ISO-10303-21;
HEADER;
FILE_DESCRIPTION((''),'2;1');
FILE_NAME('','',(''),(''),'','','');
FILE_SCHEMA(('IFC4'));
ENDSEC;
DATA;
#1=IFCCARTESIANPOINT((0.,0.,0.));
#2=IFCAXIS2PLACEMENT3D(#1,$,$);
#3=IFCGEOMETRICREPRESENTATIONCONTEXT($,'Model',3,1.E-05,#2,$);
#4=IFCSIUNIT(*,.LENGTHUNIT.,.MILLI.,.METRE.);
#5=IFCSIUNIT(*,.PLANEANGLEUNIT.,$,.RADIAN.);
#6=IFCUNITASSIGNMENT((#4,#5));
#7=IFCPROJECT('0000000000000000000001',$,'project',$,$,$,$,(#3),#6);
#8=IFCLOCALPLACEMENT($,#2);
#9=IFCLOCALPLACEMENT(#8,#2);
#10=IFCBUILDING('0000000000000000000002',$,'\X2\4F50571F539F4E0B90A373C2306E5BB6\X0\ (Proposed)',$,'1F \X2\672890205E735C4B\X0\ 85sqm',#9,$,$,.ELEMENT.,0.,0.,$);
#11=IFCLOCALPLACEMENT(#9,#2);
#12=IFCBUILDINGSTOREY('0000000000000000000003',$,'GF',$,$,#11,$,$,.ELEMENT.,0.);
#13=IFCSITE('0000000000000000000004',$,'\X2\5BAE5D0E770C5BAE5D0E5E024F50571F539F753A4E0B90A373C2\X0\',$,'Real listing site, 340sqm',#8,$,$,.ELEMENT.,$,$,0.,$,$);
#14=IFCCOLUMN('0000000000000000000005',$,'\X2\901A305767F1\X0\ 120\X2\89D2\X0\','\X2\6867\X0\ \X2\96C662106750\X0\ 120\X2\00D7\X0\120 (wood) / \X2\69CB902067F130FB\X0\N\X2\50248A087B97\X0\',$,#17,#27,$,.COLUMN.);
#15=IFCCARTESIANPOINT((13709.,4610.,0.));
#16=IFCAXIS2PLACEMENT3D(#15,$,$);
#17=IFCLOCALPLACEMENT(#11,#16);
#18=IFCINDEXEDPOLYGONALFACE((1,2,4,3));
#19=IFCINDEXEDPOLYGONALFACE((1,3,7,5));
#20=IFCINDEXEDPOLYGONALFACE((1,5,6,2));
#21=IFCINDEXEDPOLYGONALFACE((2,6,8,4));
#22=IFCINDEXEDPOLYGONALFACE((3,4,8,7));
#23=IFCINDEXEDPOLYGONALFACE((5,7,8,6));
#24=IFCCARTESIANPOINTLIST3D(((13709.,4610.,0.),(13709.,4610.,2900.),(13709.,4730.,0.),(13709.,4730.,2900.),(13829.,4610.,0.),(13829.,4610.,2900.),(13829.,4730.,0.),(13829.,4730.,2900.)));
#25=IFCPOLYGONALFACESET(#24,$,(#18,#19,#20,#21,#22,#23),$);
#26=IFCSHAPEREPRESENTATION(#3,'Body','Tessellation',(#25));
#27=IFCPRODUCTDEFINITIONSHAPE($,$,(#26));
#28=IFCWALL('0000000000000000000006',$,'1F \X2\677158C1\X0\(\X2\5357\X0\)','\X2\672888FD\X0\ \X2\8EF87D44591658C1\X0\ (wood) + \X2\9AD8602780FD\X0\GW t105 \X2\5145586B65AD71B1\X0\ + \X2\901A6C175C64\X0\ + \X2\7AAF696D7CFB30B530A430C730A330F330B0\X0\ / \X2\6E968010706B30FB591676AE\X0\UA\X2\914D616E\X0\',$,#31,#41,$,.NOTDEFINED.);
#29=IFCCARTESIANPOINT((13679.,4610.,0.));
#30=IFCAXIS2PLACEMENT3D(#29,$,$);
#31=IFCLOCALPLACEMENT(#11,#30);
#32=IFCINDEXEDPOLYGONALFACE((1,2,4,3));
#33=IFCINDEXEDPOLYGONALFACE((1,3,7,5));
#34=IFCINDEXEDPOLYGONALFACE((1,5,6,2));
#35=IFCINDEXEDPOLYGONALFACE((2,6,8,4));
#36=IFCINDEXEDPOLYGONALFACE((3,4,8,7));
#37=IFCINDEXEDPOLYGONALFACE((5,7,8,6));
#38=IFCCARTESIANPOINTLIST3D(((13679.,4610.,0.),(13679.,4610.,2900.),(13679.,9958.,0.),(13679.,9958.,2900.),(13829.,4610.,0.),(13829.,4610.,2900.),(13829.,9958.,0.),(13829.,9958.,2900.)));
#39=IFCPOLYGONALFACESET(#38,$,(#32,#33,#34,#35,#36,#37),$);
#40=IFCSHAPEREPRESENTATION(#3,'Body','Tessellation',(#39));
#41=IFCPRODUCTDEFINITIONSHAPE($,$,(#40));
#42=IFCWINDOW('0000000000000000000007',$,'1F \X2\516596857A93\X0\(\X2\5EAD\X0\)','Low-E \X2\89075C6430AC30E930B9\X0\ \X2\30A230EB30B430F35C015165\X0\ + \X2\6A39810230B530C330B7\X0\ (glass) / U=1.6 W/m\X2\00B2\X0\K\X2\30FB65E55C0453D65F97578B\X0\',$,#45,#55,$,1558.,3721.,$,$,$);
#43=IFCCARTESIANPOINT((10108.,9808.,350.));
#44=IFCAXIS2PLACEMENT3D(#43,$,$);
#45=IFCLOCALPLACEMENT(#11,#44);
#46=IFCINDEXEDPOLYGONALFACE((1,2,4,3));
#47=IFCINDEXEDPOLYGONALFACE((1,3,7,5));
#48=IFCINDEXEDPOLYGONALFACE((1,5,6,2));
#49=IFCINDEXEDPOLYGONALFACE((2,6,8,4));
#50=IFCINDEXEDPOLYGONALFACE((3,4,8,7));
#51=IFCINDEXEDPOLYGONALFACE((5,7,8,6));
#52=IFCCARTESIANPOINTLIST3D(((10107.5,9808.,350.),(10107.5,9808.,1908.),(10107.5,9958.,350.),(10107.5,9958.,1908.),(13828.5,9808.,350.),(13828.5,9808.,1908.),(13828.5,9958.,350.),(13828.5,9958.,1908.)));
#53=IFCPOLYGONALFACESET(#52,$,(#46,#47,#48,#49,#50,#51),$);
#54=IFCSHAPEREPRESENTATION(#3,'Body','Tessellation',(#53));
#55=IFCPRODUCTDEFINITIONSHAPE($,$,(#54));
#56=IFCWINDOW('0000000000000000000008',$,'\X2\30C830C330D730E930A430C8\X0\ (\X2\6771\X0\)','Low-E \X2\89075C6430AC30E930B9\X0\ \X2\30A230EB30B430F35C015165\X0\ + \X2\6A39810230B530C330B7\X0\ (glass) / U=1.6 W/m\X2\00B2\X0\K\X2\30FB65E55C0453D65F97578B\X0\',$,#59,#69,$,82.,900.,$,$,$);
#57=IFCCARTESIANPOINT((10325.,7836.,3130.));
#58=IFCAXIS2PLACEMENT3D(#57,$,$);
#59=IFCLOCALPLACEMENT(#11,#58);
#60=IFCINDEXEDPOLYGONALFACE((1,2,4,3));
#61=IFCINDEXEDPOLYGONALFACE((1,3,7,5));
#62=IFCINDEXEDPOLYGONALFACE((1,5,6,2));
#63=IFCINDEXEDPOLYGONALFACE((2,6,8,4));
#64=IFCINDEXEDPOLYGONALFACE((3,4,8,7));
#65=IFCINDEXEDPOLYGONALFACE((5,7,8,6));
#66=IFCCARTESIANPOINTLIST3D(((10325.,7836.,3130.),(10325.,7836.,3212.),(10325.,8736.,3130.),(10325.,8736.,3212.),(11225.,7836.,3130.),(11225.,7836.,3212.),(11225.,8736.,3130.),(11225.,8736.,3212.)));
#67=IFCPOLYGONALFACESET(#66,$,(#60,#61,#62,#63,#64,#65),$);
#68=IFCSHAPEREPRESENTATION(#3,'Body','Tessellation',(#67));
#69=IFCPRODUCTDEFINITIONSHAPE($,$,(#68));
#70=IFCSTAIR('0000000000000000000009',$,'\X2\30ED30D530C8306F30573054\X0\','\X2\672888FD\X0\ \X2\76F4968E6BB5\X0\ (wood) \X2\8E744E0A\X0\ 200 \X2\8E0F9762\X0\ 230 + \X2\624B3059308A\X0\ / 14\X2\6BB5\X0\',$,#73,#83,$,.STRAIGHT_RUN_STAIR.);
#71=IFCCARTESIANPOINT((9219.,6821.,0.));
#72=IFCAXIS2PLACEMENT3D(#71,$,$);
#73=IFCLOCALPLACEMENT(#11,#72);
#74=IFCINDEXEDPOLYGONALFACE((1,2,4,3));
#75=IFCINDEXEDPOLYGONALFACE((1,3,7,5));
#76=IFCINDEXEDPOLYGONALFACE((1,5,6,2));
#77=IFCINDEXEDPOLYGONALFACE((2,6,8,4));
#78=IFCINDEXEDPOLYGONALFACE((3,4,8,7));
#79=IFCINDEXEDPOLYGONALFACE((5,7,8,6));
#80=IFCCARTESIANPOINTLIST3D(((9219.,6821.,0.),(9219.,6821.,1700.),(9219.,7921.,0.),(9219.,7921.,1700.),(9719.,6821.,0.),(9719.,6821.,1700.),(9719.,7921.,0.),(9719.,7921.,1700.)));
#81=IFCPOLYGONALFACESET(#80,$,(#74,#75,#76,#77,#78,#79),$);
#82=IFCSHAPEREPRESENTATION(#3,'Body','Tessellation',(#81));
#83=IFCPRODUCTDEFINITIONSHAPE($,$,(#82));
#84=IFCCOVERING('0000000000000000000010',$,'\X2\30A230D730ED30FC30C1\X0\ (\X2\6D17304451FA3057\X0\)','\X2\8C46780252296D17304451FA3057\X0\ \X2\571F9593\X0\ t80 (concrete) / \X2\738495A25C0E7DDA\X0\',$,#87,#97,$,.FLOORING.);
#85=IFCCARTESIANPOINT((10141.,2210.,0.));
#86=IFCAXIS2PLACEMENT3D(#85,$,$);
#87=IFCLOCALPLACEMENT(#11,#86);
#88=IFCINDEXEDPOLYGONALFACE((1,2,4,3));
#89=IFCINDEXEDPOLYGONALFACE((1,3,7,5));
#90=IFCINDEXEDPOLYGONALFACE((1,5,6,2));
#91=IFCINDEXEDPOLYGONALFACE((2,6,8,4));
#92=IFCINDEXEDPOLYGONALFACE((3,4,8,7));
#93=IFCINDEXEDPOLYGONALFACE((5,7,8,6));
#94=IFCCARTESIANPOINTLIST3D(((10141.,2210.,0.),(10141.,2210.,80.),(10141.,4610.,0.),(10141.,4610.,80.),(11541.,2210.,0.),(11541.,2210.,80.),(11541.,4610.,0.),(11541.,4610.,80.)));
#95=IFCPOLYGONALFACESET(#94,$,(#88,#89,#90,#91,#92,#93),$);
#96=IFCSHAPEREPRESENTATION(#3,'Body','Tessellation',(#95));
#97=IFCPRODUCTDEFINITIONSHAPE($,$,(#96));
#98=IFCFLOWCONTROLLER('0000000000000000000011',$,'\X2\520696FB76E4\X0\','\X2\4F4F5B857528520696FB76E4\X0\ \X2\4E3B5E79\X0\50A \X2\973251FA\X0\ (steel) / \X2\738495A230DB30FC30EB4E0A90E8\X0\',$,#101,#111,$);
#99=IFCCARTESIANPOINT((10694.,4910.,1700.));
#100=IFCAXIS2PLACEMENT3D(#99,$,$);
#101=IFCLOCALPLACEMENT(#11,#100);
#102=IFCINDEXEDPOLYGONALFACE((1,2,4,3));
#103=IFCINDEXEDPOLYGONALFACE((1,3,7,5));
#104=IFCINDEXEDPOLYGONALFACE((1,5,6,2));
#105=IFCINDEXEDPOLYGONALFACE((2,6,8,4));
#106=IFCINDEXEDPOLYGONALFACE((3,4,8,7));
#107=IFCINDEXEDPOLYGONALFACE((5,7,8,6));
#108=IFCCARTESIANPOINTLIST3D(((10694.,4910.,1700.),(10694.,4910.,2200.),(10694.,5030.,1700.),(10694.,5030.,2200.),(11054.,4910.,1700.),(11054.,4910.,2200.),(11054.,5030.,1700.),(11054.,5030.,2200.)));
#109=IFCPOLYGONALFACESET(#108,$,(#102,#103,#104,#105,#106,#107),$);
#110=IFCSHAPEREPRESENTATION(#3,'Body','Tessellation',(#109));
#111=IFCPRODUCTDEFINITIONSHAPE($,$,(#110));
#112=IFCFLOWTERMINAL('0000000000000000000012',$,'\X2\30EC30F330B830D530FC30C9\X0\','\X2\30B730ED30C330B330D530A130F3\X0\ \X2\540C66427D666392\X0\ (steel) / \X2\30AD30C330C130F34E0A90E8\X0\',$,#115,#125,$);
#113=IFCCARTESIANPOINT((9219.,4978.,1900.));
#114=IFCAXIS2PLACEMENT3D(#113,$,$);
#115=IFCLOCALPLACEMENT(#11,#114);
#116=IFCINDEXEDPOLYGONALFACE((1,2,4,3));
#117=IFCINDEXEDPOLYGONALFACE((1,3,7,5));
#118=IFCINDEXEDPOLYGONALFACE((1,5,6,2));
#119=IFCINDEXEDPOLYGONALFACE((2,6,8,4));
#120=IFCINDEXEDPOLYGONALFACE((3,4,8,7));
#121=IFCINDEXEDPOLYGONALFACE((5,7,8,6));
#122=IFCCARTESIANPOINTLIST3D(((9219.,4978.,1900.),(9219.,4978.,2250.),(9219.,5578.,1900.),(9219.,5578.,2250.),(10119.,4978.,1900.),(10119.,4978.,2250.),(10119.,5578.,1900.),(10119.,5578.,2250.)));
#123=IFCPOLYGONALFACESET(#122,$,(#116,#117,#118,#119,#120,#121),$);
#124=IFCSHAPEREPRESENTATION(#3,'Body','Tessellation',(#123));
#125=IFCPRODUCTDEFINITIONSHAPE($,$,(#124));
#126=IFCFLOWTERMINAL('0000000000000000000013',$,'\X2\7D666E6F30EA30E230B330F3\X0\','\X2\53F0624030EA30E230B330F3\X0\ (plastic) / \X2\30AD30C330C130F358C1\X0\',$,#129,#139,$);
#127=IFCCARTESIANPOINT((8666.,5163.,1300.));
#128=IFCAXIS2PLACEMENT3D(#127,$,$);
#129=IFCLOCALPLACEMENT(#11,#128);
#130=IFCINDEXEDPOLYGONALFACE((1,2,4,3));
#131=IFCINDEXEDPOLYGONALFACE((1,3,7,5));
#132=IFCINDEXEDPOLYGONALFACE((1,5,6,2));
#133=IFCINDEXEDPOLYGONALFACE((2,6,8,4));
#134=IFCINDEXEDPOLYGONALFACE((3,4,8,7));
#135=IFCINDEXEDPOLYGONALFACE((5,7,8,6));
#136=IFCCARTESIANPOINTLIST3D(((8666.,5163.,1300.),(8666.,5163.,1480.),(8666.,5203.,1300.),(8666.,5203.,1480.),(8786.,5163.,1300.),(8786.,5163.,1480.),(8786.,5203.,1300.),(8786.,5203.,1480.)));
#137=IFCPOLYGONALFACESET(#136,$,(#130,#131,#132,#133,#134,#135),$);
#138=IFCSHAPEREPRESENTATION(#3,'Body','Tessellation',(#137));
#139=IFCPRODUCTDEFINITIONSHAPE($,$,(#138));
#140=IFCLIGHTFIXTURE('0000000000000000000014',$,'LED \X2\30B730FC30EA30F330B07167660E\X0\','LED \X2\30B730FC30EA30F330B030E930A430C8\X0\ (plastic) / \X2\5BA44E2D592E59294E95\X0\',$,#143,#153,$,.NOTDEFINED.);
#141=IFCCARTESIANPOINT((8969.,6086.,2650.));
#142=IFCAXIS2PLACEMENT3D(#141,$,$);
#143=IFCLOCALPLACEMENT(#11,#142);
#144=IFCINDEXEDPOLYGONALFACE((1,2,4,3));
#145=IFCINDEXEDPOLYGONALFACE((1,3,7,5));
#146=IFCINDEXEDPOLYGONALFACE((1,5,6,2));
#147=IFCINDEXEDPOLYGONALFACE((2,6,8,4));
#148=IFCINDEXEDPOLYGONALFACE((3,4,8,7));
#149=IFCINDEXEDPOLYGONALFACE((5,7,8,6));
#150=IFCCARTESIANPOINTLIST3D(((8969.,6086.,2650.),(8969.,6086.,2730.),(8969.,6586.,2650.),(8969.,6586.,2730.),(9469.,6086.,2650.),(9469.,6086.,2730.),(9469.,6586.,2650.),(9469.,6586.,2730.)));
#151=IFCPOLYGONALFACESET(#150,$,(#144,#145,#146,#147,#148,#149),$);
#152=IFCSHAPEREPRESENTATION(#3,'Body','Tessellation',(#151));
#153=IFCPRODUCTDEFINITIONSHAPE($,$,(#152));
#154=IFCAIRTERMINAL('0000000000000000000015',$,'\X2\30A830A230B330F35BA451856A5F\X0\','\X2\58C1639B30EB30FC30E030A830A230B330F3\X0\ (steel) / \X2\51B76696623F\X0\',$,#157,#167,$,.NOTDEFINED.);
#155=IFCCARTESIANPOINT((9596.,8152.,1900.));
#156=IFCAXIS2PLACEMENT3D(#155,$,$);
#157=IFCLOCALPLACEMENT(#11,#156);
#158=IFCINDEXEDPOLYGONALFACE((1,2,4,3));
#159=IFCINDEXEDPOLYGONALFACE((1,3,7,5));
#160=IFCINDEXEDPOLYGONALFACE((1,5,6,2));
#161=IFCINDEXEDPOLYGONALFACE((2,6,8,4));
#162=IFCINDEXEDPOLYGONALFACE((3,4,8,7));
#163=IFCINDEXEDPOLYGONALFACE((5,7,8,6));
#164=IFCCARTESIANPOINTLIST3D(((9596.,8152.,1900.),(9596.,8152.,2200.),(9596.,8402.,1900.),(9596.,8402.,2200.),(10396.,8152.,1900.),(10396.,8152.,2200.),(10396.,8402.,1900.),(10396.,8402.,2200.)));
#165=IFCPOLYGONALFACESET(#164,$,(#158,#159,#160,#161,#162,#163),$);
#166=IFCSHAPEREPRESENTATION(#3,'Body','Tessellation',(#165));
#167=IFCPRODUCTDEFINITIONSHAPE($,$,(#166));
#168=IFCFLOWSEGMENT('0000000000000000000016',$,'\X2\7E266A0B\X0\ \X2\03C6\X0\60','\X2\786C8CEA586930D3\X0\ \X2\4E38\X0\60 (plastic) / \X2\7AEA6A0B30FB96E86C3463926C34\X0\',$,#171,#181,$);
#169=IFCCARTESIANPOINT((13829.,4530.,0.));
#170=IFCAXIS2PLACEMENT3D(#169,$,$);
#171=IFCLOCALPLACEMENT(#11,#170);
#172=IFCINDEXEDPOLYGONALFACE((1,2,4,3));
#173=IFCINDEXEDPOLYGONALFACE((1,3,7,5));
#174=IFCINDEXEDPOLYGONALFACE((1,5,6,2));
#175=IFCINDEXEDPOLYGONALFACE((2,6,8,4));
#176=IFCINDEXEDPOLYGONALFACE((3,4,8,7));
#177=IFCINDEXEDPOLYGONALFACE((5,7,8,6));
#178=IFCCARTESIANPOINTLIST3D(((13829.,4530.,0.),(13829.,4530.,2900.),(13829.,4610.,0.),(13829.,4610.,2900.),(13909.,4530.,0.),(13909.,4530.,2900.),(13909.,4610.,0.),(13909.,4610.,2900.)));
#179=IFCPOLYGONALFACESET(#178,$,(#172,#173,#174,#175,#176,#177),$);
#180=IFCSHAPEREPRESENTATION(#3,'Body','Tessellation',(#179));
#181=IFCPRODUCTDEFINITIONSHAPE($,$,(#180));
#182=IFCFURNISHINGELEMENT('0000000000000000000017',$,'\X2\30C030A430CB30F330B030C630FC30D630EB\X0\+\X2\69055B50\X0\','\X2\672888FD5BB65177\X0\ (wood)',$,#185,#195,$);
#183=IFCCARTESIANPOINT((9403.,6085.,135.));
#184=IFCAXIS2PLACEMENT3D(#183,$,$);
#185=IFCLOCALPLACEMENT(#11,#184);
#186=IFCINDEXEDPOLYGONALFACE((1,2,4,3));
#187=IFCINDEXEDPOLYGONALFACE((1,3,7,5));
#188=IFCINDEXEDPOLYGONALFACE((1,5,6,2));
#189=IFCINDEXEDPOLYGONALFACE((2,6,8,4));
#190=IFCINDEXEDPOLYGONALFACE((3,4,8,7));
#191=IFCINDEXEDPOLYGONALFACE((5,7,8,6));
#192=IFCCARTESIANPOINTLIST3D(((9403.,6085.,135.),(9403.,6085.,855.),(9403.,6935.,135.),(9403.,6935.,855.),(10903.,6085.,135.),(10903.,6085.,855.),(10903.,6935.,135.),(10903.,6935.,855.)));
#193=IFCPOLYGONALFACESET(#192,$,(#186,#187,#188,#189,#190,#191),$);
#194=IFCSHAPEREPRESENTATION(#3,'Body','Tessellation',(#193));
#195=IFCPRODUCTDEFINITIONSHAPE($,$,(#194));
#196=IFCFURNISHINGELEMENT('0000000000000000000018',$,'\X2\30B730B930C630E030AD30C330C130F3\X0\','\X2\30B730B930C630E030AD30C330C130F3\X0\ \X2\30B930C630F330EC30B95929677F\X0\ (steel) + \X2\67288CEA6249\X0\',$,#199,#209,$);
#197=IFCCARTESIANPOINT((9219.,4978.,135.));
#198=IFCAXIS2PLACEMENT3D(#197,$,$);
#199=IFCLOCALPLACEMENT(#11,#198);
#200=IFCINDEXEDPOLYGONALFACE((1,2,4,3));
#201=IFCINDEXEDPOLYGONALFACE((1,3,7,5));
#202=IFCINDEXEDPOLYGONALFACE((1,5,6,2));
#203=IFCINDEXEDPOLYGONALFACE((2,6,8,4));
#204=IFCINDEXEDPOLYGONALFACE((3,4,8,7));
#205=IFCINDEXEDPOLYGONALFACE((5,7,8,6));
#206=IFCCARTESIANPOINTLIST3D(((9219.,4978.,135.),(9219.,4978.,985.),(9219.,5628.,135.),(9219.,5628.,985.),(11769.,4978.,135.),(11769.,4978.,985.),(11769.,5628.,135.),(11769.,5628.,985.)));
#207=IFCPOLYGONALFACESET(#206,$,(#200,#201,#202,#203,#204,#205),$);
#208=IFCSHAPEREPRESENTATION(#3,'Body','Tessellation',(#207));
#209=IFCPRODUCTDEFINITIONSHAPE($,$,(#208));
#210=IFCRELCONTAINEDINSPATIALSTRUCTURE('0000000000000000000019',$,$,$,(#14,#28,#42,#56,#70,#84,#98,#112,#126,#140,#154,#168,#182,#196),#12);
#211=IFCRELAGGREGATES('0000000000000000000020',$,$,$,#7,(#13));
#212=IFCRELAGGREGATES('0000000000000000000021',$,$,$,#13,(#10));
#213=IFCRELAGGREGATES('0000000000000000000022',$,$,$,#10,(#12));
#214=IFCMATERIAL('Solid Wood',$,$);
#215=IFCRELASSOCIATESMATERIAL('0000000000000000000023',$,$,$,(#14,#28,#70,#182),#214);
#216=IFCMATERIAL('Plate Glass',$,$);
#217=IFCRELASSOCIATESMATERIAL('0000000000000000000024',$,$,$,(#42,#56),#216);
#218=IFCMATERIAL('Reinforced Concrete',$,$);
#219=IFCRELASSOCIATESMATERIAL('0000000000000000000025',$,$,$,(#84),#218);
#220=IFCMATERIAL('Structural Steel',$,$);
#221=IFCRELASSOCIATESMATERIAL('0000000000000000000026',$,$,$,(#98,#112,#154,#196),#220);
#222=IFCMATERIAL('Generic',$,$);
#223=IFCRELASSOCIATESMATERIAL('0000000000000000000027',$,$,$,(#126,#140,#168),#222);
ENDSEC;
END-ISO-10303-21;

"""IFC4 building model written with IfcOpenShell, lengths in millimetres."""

from ifc_helpers import new_model, si_unit, frame, frame_2d, origin, place, context, project, spatial, rectangle, extrude, material, element, fill, save


model = new_model("IFC4")

# Units and contexts
model_context = context("Model", 3, precision=1e-05, world=origin())
ifc_project = project(units=[si_unit("LENGTHUNIT", "METRE", prefix="MILLI"), si_unit("PLANEANGLEUNIT", "RADIAN")], contexts=[model_context])

# Site, building, storey
site_placement = place(None, origin())
site = spatial("IfcSite", under=ifc_project, at=site_placement, Name="宮崎県宮崎市佐土原町下那珂", ObjectType="Real listing site, 340sqm", CompositionType="ELEMENT", RefElevation=0.0)
building_placement = place(site_placement, origin())
building = spatial("IfcBuilding", under=site, at=building_placement, Name="佐土原下那珂の家 (Proposed)", ObjectType="1F 木造平屋 85sqm", CompositionType="ELEMENT", ElevationOfRefHeight=0.0, ElevationOfTerrain=0.0)
storey_placement = place(building_placement, origin())
storey = spatial("IfcBuildingStorey", under=building, at=storey_placement, Name="GF", CompositionType="ELEMENT", Elevation=0.0)

# Column
ifc_material_1 = material(Name="Solid Wood")
column_1_placement = place(storey_placement, frame((13709.0, 4610.0, 0.0)))
element("IfcColumn", 1, at=column_1_placement, inside=storey, material=ifc_material_1, Name="通し柱 120角", Description="桧 集成材 120×120 (wood) / 構造柱・N値計算", PredefinedType="COLUMN", context=model_context, shape_type="SweptSolid", body=[
    extrude(rectangle(XDim=120.0, YDim=120.0, at=frame_2d((60.0, 60.0))), frame((13709.0, 4610.0, 0.0)), (0.0, 0.0, 1.0), 2900.0),
])

# Wall, opening, window
wall_1_placement = place(storey_placement, frame((13679.0, 4610.0, 0.0)))
wall_1 = element("IfcWall", 2, at=wall_1_placement, inside=storey, material=ifc_material_1, Name="1F 東壁(南)", Description="木製 軸組外壁 (wood) + 高性能GW t105 充填断熱 + 通気層 + 窯業系サイディング / 準耐火・外皮UA配慮", PredefinedType="NOTDEFINED", context=model_context, shape_type="SweptSolid", body=[
    extrude(rectangle(XDim=150.0, YDim=5348.0, at=frame_2d((75.0, 2674.0))), frame((13679.0, 4610.0, 0.0)), (0.0, 0.0, 1.0), 2900.0),
])
opening_placement = place(storey_placement, frame((10108.0, 9808.0, 350.0)))
opening = element("IfcOpeningElement", 3, at=opening_placement, cuts=wall_1, PredefinedType="NOTDEFINED", context=model_context, shape_type="SweptSolid", body=[
    extrude(rectangle(XDim=3721.0, YDim=150.0, at=frame_2d((1860.0, 75.0))), frame((10108.0, 9808.0, 350.0)), (0.0, 0.0, 1.0), 1558.0),
])
ifc_material_2 = material(Name="Plate Glass")
window_1_placement = place(storey_placement, frame((10108.0, 9808.0, 350.0)))
window_1 = element("IfcWindow", 4, at=window_1_placement, inside=storey, material=ifc_material_2, Name="1F 入隅窓(庭)", Description="Low-E 複層ガラス アルゴン封入 + 樹脂サッシ (glass) / U=1.6 W/m²K・日射取得型", OverallHeight=1558.0, OverallWidth=3721.0, context=model_context, shape_type="SweptSolid", body=[
    extrude(rectangle(XDim=3721.0, YDim=150.0, at=frame_2d((1860.0, 75.0))), frame((10108.0, 9808.0, 350.0)), (0.0, 0.0, 1.0), 1558.0),
])
fill(opening, window_1)

# Window
window_2_placement = place(storey_placement, frame((10325.0, 7836.0, 3130.0)))
element("IfcWindow", 5, at=window_2_placement, inside=storey, material=ifc_material_2, Name="トップライト (東)", Description="Low-E 複層ガラス アルゴン封入 + 樹脂サッシ (glass) / U=1.6 W/m²K・日射取得型", OverallHeight=82.0, OverallWidth=900.0, context=model_context, shape_type="SweptSolid", body=[
    extrude(rectangle(XDim=900.0, YDim=900.0, at=frame_2d((450.0, 450.0))), frame((10325.0, 7836.0, 3130.0)), (0.0, 0.0, 1.0), 82.0),
])

# Stair
stair_placement = place(storey_placement, frame((9219.0, 6821.0, 0.0)))
element("IfcStair", 6, at=stair_placement, inside=storey, material=ifc_material_1, Name="ロフトはしご", Description="木製 直階段 (wood) 蹴上 200 踏面 230 + 手すり / 14段", PredefinedType="STRAIGHT_RUN_STAIR", context=model_context, shape_type="SweptSolid", body=[
    extrude(rectangle(XDim=500.0, YDim=1100.0, at=frame_2d((250.0, 550.0))), frame((9219.0, 6821.0, 0.0)), (0.0, 0.0, 1.0), 1700.0),
])

# Covering
ifc_material_3 = material(Name="Reinforced Concrete")
covering_placement = place(storey_placement, frame((10141.0, 2210.0, 0.0)))
element("IfcCovering", 7, at=covering_placement, inside=storey, material=ifc_material_3, Name="アプローチ (洗い出し)", Description="豆砂利洗い出し 土間 t80 (concrete) / 玄関導線", PredefinedType="FLOORING", context=model_context, shape_type="SweptSolid", body=[
    extrude(rectangle(XDim=1400.0, YDim=2400.0, at=frame_2d((700.0, 1200.0))), frame((10141.0, 2210.0, 0.0)), (0.0, 0.0, 1.0), 80.0),
])

# Flow controller
ifc_material_4 = material(Name="Structural Steel")
flow_controller_placement = place(storey_placement, frame((10694.0, 4910.0, 1700.0)))
element("IfcFlowController", 8, at=flow_controller_placement, inside=storey, material=ifc_material_4, Name="分電盤", Description="住宅用分電盤 主幹50A 露出 (steel) / 玄関ホール上部", context=model_context, shape_type="SweptSolid", body=[
    extrude(rectangle(XDim=360.0, YDim=120.0, at=frame_2d((180.0, 60.0))), frame((10694.0, 4910.0, 1700.0)), (0.0, 0.0, 1.0), 500.0),
])

# Flow terminals
flow_terminal_1_placement = place(storey_placement, frame((9219.0, 4978.0, 1900.0)))
element("IfcFlowTerminal", 9, at=flow_terminal_1_placement, inside=storey, material=ifc_material_4, Name="レンジフード", Description="シロッコファン 同時給排 (steel) / キッチン上部", context=model_context, shape_type="SweptSolid", body=[
    extrude(rectangle(XDim=900.0, YDim=600.0, at=frame_2d((450.0, 300.0))), frame((9219.0, 4978.0, 1900.0)), (0.0, 0.0, 1.0), 350.0),
])
ifc_material_5 = material(Name="Generic")
flow_terminal_2_placement = place(storey_placement, frame((8666.0, 5163.0, 1300.0)))
element("IfcFlowTerminal", 10, at=flow_terminal_2_placement, inside=storey, material=ifc_material_5, Name="給湯リモコン", Description="台所リモコン (plastic) / キッチン壁", context=model_context, shape_type="SweptSolid", body=[
    extrude(rectangle(XDim=120.0, YDim=40.0, at=frame_2d((60.0, 20.0))), frame((8666.0, 5163.0, 1300.0)), (0.0, 0.0, 1.0), 180.0),
])

# Light fixture
light_fixture_placement = place(storey_placement, frame((8969.0, 6086.0, 2650.0)))
element("IfcLightFixture", 11, at=light_fixture_placement, inside=storey, material=ifc_material_5, Name="LED シーリング照明", Description="LED シーリングライト (plastic) / 室中央天井", PredefinedType="NOTDEFINED", context=model_context, shape_type="SweptSolid", body=[
    extrude(rectangle(XDim=500.0, YDim=500.0, at=frame_2d((250.0, 250.0))), frame((8969.0, 6086.0, 2650.0)), (0.0, 0.0, 1.0), 80.0),
])

# Air terminal
air_terminal_placement = place(storey_placement, frame((9596.0, 8152.0, 1900.0)))
element("IfcAirTerminal", 12, at=air_terminal_placement, inside=storey, material=ifc_material_4, Name="エアコン室内機", Description="壁掛ルームエアコン (steel) / 冷暖房", PredefinedType="NOTDEFINED", context=model_context, shape_type="SweptSolid", body=[
    extrude(rectangle(XDim=800.0, YDim=250.0, at=frame_2d((400.0, 125.0))), frame((9596.0, 8152.0, 1900.0)), (0.0, 0.0, 1.0), 300.0),
])

# Flow segment
flow_segment_placement = place(storey_placement, frame((13829.0, 4530.0, 0.0)))
element("IfcFlowSegment", 13, at=flow_segment_placement, inside=storey, material=ifc_material_5, Name="縦樋 φ60", Description="硬質塩ビ 丸60 (plastic) / 竪樋・雨水排水", context=model_context, shape_type="SweptSolid", body=[
    extrude(rectangle(XDim=80.0, YDim=80.0, at=frame_2d((40.0, 40.0))), frame((13829.0, 4530.0, 0.0)), (0.0, 0.0, 1.0), 2900.0),
])

# Furnishing elements
furnishing_1_placement = place(storey_placement, frame((9403.0, 6085.0, 135.0)))
element("IfcFurnishingElement", 14, at=furnishing_1_placement, inside=storey, material=ifc_material_1, Name="ダイニングテーブル+椅子", Description="木製家具 (wood)", context=model_context, shape_type="SweptSolid", body=[
    extrude(rectangle(XDim=1500.0, YDim=850.0, at=frame_2d((750.0, 425.0))), frame((9403.0, 6085.0, 135.0)), (0.0, 0.0, 1.0), 720.0),
])
furnishing_2_placement = place(storey_placement, frame((9219.0, 4978.0, 135.0)))
element("IfcFurnishingElement", 15, at=furnishing_2_placement, inside=storey, material=ifc_material_4, Name="システムキッチン", Description="システムキッチン ステンレス天板 (steel) + 木質扉", context=model_context, shape_type="SweptSolid", body=[
    extrude(rectangle(XDim=2550.0, YDim=650.0, at=frame_2d((1275.0, 325.0))), frame((9219.0, 4978.0, 135.0)), (0.0, 0.0, 1.0), 850.0),
])

save(model, "model.ifc")
